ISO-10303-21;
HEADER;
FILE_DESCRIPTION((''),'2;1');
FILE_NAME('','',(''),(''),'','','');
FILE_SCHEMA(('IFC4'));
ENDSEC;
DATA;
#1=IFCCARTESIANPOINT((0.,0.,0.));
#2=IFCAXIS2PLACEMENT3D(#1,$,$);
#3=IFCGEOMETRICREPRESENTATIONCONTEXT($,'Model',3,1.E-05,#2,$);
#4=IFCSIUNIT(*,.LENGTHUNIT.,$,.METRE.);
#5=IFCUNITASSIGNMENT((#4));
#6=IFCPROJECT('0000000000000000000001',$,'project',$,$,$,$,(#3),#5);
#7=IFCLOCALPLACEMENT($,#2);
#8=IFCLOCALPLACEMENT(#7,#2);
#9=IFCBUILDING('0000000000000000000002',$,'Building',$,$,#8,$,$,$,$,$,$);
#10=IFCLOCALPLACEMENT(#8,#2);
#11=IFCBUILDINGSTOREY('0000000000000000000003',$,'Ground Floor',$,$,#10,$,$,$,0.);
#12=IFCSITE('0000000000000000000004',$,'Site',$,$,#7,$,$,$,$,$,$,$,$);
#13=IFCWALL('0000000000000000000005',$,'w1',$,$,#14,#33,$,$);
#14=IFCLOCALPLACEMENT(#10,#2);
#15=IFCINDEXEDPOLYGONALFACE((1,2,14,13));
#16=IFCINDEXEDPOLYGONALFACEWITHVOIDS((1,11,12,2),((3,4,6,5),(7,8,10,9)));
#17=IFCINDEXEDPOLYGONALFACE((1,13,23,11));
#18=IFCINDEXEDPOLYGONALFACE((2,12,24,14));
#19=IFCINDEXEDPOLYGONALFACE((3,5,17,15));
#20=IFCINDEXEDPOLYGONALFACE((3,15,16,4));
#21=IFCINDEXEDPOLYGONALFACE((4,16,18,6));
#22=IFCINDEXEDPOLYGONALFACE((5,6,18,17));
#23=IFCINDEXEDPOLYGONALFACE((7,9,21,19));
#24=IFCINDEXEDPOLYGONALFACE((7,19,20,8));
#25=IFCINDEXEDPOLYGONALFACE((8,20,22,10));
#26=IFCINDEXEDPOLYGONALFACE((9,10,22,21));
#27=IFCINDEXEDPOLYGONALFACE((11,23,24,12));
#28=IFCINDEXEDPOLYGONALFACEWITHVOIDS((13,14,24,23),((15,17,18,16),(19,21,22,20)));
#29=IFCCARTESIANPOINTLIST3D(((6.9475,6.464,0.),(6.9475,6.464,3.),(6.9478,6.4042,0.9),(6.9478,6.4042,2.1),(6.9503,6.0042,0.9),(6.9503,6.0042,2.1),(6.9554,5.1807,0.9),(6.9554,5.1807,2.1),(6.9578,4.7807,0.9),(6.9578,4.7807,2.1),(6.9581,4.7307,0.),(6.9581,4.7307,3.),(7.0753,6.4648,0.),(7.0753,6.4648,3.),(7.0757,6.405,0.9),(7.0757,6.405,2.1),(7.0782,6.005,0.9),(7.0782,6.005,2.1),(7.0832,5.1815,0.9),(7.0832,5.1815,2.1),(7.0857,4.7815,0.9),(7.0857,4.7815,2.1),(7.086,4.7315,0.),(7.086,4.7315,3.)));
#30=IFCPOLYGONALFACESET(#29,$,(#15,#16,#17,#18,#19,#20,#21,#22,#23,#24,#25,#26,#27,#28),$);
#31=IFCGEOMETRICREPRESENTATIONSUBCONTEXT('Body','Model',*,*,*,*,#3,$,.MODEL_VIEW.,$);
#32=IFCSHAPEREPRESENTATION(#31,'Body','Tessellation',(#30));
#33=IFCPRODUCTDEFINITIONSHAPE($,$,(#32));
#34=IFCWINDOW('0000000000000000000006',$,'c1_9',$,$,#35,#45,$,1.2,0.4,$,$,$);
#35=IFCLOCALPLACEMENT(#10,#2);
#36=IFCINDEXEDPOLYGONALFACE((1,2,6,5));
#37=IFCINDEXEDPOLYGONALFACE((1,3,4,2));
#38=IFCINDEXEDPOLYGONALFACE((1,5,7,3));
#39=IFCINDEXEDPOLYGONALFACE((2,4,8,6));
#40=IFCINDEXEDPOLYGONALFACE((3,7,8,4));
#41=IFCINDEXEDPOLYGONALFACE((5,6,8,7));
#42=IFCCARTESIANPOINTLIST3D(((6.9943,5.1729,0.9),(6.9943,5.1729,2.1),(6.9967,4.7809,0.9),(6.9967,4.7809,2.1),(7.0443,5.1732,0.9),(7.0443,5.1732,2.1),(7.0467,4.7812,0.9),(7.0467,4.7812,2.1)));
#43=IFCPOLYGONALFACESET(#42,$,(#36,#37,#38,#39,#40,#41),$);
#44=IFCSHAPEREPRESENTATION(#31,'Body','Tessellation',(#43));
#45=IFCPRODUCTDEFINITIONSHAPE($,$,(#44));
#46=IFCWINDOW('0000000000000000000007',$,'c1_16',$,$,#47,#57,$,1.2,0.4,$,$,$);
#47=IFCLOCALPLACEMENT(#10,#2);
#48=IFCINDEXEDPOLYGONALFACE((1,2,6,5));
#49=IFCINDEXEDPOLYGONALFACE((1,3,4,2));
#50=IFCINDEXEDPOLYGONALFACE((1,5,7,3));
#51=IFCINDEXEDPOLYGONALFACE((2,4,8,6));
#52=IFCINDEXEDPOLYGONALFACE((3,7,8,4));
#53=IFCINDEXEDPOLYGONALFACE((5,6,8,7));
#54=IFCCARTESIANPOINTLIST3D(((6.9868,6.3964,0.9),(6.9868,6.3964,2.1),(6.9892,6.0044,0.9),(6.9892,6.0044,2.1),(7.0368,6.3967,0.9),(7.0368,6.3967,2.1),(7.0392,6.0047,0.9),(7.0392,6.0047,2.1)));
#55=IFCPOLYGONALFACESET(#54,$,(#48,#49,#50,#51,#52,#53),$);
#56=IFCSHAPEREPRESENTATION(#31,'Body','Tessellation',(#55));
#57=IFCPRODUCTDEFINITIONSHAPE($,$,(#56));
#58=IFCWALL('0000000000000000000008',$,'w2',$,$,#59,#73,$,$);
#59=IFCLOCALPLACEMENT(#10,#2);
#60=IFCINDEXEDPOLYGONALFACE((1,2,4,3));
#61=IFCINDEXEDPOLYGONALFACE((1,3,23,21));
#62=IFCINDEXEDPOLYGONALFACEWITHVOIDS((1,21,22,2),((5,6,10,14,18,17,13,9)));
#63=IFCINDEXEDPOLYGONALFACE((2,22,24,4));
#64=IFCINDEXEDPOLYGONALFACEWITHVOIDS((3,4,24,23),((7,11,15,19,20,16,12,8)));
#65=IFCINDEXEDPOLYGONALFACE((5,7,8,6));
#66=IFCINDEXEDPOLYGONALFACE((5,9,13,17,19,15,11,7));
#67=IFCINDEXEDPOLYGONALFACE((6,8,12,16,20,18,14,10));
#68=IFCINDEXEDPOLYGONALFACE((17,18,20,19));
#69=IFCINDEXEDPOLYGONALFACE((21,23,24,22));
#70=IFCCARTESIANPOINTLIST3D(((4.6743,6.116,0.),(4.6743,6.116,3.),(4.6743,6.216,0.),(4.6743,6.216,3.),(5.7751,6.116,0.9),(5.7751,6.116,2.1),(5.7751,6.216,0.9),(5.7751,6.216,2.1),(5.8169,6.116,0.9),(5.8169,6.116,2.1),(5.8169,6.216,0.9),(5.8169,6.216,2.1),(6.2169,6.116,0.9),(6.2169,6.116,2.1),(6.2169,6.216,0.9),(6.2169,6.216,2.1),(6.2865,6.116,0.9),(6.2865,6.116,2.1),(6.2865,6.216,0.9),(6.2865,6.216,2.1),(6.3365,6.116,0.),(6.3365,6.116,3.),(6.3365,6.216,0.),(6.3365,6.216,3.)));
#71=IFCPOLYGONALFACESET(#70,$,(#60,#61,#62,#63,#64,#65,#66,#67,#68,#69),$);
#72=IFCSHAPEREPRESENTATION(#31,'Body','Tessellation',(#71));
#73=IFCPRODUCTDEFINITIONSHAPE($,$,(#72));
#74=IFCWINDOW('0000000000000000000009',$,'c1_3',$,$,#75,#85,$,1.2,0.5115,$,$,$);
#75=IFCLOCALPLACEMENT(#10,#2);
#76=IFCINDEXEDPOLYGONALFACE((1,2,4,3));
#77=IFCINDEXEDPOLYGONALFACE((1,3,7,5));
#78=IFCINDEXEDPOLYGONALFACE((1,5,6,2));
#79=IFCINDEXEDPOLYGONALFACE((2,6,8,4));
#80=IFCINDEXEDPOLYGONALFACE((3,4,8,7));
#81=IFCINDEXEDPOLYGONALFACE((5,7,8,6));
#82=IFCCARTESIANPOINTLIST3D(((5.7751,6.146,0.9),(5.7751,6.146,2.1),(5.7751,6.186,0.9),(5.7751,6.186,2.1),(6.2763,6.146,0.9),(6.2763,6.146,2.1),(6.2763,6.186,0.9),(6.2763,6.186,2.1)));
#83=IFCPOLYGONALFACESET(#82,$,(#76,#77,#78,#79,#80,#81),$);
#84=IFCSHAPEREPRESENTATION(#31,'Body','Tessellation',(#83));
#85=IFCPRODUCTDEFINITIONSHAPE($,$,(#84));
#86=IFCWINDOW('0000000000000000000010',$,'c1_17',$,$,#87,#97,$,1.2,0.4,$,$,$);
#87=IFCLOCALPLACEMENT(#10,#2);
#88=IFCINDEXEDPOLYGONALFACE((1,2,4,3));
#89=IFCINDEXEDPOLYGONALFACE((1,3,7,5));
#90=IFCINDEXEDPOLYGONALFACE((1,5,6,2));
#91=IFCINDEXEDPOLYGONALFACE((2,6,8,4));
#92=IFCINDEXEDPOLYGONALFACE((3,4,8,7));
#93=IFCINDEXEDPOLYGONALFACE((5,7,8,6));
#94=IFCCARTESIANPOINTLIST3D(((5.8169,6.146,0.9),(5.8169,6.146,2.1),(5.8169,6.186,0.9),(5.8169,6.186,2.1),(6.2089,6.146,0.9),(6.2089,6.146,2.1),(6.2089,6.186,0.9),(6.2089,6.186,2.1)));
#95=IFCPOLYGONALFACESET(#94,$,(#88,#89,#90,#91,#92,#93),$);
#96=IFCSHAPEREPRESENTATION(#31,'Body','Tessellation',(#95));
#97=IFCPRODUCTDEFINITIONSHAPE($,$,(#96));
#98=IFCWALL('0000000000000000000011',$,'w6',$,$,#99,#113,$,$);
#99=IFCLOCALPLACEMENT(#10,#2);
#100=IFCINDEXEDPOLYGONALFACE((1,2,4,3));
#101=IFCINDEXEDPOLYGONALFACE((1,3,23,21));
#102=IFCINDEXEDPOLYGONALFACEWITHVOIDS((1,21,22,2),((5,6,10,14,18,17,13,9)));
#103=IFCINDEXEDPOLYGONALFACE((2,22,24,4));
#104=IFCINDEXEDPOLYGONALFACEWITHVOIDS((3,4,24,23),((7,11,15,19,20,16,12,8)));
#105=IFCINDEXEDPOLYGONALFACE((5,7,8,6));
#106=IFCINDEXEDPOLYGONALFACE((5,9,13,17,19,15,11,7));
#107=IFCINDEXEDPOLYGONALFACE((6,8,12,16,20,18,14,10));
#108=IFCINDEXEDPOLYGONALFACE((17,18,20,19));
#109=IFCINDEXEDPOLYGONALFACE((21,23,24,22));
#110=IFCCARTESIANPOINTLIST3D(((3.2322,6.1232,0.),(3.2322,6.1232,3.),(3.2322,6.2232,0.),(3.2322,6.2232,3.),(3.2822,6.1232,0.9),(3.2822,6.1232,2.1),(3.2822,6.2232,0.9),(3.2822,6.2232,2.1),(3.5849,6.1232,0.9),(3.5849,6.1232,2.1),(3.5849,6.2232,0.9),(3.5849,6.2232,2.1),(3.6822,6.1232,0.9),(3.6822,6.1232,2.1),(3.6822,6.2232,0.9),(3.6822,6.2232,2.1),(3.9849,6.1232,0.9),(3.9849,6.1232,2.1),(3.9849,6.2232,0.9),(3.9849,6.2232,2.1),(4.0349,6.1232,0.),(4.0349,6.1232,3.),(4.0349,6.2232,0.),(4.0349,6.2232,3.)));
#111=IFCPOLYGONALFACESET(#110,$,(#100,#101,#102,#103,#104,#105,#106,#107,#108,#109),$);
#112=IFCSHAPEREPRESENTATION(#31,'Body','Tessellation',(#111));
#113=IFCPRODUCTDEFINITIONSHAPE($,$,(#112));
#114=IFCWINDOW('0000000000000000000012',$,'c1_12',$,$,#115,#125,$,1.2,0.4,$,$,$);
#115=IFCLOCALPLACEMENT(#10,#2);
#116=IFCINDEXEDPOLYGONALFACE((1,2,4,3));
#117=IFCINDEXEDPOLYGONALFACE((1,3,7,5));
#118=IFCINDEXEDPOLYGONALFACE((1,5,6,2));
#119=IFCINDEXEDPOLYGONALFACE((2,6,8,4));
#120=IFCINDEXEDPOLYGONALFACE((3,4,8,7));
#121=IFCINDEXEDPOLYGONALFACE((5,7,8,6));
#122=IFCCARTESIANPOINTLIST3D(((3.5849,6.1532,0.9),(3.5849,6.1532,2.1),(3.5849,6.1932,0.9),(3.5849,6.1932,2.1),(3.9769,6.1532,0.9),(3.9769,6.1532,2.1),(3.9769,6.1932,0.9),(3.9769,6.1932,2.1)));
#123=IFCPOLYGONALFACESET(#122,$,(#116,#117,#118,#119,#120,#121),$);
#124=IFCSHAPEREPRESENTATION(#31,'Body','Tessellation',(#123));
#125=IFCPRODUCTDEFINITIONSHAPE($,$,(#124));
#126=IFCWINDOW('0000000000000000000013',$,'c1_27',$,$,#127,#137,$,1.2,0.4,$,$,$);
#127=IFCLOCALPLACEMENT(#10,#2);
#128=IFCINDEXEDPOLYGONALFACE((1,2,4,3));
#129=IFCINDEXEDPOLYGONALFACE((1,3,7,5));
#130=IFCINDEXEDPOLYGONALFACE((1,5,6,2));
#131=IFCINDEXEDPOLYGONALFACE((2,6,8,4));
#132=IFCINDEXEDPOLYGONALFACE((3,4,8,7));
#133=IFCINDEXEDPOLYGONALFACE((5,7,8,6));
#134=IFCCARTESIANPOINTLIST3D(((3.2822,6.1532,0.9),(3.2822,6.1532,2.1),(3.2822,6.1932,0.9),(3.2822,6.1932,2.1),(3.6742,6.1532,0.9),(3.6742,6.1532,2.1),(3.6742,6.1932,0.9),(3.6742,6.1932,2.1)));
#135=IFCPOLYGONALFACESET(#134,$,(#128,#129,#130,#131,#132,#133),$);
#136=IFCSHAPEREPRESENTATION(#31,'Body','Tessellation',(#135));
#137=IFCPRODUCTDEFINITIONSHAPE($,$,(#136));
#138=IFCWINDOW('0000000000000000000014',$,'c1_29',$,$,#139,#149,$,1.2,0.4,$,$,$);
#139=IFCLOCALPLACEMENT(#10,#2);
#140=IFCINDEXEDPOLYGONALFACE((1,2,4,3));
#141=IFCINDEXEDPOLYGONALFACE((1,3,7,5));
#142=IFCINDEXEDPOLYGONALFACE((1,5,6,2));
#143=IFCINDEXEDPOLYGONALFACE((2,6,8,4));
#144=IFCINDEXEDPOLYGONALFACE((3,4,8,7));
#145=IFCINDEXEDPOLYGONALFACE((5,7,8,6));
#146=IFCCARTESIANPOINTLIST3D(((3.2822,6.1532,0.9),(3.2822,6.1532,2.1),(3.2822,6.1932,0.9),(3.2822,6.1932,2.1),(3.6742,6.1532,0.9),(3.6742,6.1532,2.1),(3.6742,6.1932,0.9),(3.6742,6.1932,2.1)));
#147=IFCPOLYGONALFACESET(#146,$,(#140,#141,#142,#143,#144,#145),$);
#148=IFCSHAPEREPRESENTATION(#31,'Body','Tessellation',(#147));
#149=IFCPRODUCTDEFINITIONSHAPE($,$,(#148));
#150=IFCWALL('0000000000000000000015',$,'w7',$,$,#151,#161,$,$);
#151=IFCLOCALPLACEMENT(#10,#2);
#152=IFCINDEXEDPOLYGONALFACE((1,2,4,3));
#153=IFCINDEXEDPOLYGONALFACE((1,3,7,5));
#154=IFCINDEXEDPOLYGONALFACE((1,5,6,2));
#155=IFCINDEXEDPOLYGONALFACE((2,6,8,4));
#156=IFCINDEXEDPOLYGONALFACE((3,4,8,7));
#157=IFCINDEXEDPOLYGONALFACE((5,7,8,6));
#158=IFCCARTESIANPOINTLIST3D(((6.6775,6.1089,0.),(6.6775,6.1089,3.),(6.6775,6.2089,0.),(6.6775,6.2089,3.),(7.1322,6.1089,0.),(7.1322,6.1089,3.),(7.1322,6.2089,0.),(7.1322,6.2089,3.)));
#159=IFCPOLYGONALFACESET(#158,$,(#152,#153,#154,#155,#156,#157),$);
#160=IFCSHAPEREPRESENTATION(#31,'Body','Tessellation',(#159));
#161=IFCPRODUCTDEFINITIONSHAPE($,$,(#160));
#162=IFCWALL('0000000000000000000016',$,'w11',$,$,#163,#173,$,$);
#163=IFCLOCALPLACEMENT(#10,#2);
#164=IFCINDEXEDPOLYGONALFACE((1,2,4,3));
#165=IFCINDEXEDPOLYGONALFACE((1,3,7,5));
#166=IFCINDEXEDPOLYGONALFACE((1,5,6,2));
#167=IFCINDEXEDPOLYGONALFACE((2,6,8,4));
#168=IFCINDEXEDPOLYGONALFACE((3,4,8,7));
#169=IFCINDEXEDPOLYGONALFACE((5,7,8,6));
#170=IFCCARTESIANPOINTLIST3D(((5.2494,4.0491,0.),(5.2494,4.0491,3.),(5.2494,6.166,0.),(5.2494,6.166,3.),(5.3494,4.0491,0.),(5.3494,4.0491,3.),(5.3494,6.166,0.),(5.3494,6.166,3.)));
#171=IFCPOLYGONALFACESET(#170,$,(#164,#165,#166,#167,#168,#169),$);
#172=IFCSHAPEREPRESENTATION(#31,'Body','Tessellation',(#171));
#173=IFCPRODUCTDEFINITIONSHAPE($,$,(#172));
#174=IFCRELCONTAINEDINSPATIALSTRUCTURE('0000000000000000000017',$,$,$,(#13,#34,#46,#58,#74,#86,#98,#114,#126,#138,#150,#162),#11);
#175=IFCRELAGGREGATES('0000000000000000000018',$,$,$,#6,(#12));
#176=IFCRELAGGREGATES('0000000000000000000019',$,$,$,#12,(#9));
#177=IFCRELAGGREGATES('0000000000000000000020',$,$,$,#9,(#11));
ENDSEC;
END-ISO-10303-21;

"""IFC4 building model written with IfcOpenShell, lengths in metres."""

from ifc_helpers import new_model, si_unit, frame, origin, place, context, subcontext, project, spatial, polyline, outline, extrude, element, fill, save


model = new_model("IFC4")

# Units and contexts
model_context = context("Model", 3, precision=1e-05, world=origin())
body_context = subcontext(model_context, "Body", "Model", "MODEL_VIEW")
ifc_project = project(units=[si_unit("LENGTHUNIT", "METRE")], contexts=[model_context])

# Site, building, storey
site_placement = place(None, origin())
site = spatial("IfcSite", under=ifc_project, at=site_placement, Name="Site")
building_placement = place(site_placement, origin())
building = spatial("IfcBuilding", under=site, at=building_placement, Name="Building")
storey_placement = place(building_placement, origin())
storey = spatial("IfcBuildingStorey", under=building, at=storey_placement, Name="Ground Floor", Elevation=0.0)

# Walls, openings, windows
wall_1_placement = place(storey_placement, frame((7.0221, 4.7311, 0.0), x_axis=(-0.006148, 0.999981, 0.0)))
wall_1 = element("IfcWall", 1, at=wall_1_placement, inside=storey, Name="w1", context=body_context, shape_type="SweptSolid", body=[
    extrude(outline(polyline([(0.0, -0.0639), (1.7333, -0.0639), (1.7333, 0.0639), (0.0, 0.0639), (0.0, -0.0639)])), origin(), (0.0, 0.0, 1.0), 3.0),
])
opening_1_placement = place(wall_1_placement, frame((0.05, 0.0, 0.0)))
opening_1 = element("IfcOpeningElement", 2, at=opening_1_placement, cuts=wall_1, context=body_context, shape_type="SweptSolid", body=[
    extrude(outline(polyline([(0.0, -0.0671), (0.4, -0.0671), (0.4, 0.0671), (0.0, 0.0671), (0.0, -0.0671)])), frame((0.0, 0.0, 0.9)), (0.0, 0.0, 1.0), 1.2),
])
opening_2_placement = place(wall_1_placement, frame((1.2735, 0.0, 0.0)))
opening_2 = element("IfcOpeningElement", 3, at=opening_2_placement, cuts=wall_1, context=body_context, shape_type="SweptSolid", body=[
    extrude(outline(polyline([(0.0, -0.0671), (0.4, -0.0671), (0.4, 0.0671), (0.0, 0.0671), (0.0, -0.0671)])), frame((0.0, 0.0, 0.9)), (0.0, 0.0, 1.0), 1.2),
])
window_1_placement = place(wall_1_placement, frame((0.05, 0.0, 0.0)))
window_1 = element("IfcWindow", 4, at=window_1_placement, inside=storey, Name="c1_9", OverallHeight=1.2, OverallWidth=0.4, context=body_context, shape_type="SweptSolid", body=[
    extrude(outline(polyline([(0.0, -0.025), (0.392, -0.025), (0.392, 0.025), (0.0, 0.025), (0.0, -0.025)])), frame((0.0, 0.0, 0.9)), (0.0, 0.0, 1.0), 1.2),
])
fill(opening_1, window_1)
window_2_placement = place(wall_1_placement, frame((1.2735, 0.0, 0.0)))
window_2 = element("IfcWindow", 5, at=window_2_placement, inside=storey, Name="c1_16", OverallHeight=1.2, OverallWidth=0.4, context=body_context, shape_type="SweptSolid", body=[
    extrude(outline(polyline([(0.0, -0.025), (0.392, -0.025), (0.392, 0.025), (0.0, 0.025), (0.0, -0.025)])), frame((0.0, 0.0, 0.9)), (0.0, 0.0, 1.0), 1.2),
])
fill(opening_2, window_2)
wall_2_placement = place(storey_placement, frame((4.6743, 6.166, 0.0), x_axis=(1.0, 0.0, 0.0)))
wall_2 = element("IfcWall", 6, at=wall_2_placement, inside=storey, Name="w2", context=body_context, shape_type="SweptSolid", body=[
    extrude(outline(polyline([(0.0, -0.05), (1.6623, -0.05), (1.6623, 0.05), (0.0, 0.05), (0.0, -0.05)])), origin(), (0.0, 0.0, 1.0), 3.0),
])
opening_3_placement = place(wall_2_placement, frame((1.1008, 0.0, 0.0)))
opening_3 = element("IfcOpeningElement", 7, at=opening_3_placement, cuts=wall_2, context=body_context, shape_type="SweptSolid", body=[
    extrude(outline(polyline([(0.0, -0.0525), (0.5115, -0.0525), (0.5115, 0.0525), (0.0, 0.0525), (0.0, -0.0525)])), frame((0.0, 0.0, 0.9)), (0.0, 0.0, 1.0), 1.2),
])
opening_4_placement = place(wall_2_placement, frame((1.1426, 0.0, 0.0)))
opening_4 = element("IfcOpeningElement", 8, at=opening_4_placement, cuts=wall_2, context=body_context, shape_type="SweptSolid", body=[
    extrude(outline(polyline([(0.0, -0.0525), (0.4, -0.0525), (0.4, 0.0525), (0.0, 0.0525), (0.0, -0.0525)])), frame((0.0, 0.0, 0.9)), (0.0, 0.0, 1.0), 1.2),
])
window_3_placement = place(wall_2_placement, frame((1.1008, 0.0, 0.0)))
window_3 = element("IfcWindow", 9, at=window_3_placement, inside=storey, Name="c1_3", OverallHeight=1.2, OverallWidth=0.5115, context=body_context, shape_type="SweptSolid", body=[
    extrude(outline(polyline([(0.0, -0.02), (0.5012, -0.02), (0.5012, 0.02), (0.0, 0.02), (0.0, -0.02)])), frame((0.0, 0.0, 0.9)), (0.0, 0.0, 1.0), 1.2),
])
fill(opening_3, window_3)
window_4_placement = place(wall_2_placement, frame((1.1426, 0.0, 0.0)))
window_4 = element("IfcWindow", 10, at=window_4_placement, inside=storey, Name="c1_17", OverallHeight=1.2, OverallWidth=0.4, context=body_context, shape_type="SweptSolid", body=[
    extrude(outline(polyline([(0.0, -0.02), (0.392, -0.02), (0.392, 0.02), (0.0, 0.02), (0.0, -0.02)])), frame((0.0, 0.0, 0.9)), (0.0, 0.0, 1.0), 1.2),
])
fill(opening_4, window_4)
wall_3_placement = place(storey_placement, frame((3.2322, 6.1732, 0.0), x_axis=(1.0, 0.0, 0.0)))
wall_3 = element("IfcWall", 11, at=wall_3_placement, inside=storey, Name="w6", context=body_context, shape_type="SweptSolid", body=[
    extrude(outline(polyline([(0.0, -0.05), (0.8027, -0.05), (0.8027, 0.05), (0.0, 0.05), (0.0, -0.05)])), origin(), (0.0, 0.0, 1.0), 3.0),
])
opening_5_placement = place(wall_3_placement, frame((0.3527, 0.0, 0.0)))
opening_5 = element("IfcOpeningElement", 12, at=opening_5_placement, cuts=wall_3, context=body_context, shape_type="SweptSolid", body=[
    extrude(outline(polyline([(0.0, -0.0525), (0.4, -0.0525), (0.4, 0.0525), (0.0, 0.0525), (0.0, -0.0525)])), frame((0.0, 0.0, 0.9)), (0.0, 0.0, 1.0), 1.2),
])
opening_6_placement = place(wall_3_placement, frame((0.05, 0.0, 0.0)))
opening_6 = element("IfcOpeningElement", 13, at=opening_6_placement, cuts=wall_3, context=body_context, shape_type="SweptSolid", body=[
    extrude(outline(polyline([(0.0, -0.0525), (0.4, -0.0525), (0.4, 0.0525), (0.0, 0.0525), (0.0, -0.0525)])), frame((0.0, 0.0, 0.9)), (0.0, 0.0, 1.0), 1.2),
])
opening_7_placement = place(wall_3_placement, frame((0.05, 0.0, 0.0)))
opening_7 = element("IfcOpeningElement", 14, at=opening_7_placement, cuts=wall_3, context=body_context, shape_type="SweptSolid", body=[
    extrude(outline(polyline([(0.0, -0.0525), (0.4, -0.0525), (0.4, 0.0525), (0.0, 0.0525), (0.0, -0.0525)])), frame((0.0, 0.0, 0.9)), (0.0, 0.0, 1.0), 1.2),
])
window_5_placement = place(wall_3_placement, frame((0.3527, 0.0, 0.0)))
window_5 = element("IfcWindow", 15, at=window_5_placement, inside=storey, Name="c1_12", OverallHeight=1.2, OverallWidth=0.4, context=body_context, shape_type="SweptSolid", body=[
    extrude(outline(polyline([(0.0, -0.02), (0.392, -0.02), (0.392, 0.02), (0.0, 0.02), (0.0, -0.02)])), frame((0.0, 0.0, 0.9)), (0.0, 0.0, 1.0), 1.2),
])
fill(opening_5, window_5)
window_6_placement = place(wall_3_placement, frame((0.05, 0.0, 0.0)))
window_6 = element("IfcWindow", 16, at=window_6_placement, inside=storey, Name="c1_27", OverallHeight=1.2, OverallWidth=0.4, context=body_context, shape_type="SweptSolid", body=[
    extrude(outline(polyline([(0.0, -0.02), (0.392, -0.02), (0.392, 0.02), (0.0, 0.02), (0.0, -0.02)])), frame((0.0, 0.0, 0.9)), (0.0, 0.0, 1.0), 1.2),
])
fill(opening_6, window_6)
window_7_placement = place(wall_3_placement, frame((0.05, 0.0, 0.0)))
window_7 = element("IfcWindow", 17, at=window_7_placement, inside=storey, Name="c1_29", OverallHeight=1.2, OverallWidth=0.4, context=body_context, shape_type="SweptSolid", body=[
    extrude(outline(polyline([(0.0, -0.02), (0.392, -0.02), (0.392, 0.02), (0.0, 0.02), (0.0, -0.02)])), frame((0.0, 0.0, 0.9)), (0.0, 0.0, 1.0), 1.2),
])
fill(opening_7, window_7)

# Walls
wall_4_placement = place(storey_placement, frame((6.6775, 6.1589, 0.0), x_axis=(1.0, 0.0, 0.0)))
element("IfcWall", 18, at=wall_4_placement, inside=storey, Name="w7", context=body_context, shape_type="SweptSolid", body=[
    extrude(outline(polyline([(0.0, -0.05), (0.4546, -0.05), (0.4546, 0.05), (0.0, 0.05), (0.0, -0.05)])), origin(), (0.0, 0.0, 1.0), 3.0),
])
wall_5_placement = place(storey_placement, frame((5.2994, 4.0491, 0.0), x_axis=(0.0, 1.0, 0.0)))
element("IfcWall", 19, at=wall_5_placement, inside=storey, Name="w11", context=body_context, shape_type="SweptSolid", body=[
    extrude(outline(polyline([(0.0, -0.05), (2.1169, -0.05), (2.1169, 0.05), (0.0, 0.05), (0.0, -0.05)])), origin(), (0.0, 0.0, 1.0), 3.0),
])

save(model, "model.ifc")
